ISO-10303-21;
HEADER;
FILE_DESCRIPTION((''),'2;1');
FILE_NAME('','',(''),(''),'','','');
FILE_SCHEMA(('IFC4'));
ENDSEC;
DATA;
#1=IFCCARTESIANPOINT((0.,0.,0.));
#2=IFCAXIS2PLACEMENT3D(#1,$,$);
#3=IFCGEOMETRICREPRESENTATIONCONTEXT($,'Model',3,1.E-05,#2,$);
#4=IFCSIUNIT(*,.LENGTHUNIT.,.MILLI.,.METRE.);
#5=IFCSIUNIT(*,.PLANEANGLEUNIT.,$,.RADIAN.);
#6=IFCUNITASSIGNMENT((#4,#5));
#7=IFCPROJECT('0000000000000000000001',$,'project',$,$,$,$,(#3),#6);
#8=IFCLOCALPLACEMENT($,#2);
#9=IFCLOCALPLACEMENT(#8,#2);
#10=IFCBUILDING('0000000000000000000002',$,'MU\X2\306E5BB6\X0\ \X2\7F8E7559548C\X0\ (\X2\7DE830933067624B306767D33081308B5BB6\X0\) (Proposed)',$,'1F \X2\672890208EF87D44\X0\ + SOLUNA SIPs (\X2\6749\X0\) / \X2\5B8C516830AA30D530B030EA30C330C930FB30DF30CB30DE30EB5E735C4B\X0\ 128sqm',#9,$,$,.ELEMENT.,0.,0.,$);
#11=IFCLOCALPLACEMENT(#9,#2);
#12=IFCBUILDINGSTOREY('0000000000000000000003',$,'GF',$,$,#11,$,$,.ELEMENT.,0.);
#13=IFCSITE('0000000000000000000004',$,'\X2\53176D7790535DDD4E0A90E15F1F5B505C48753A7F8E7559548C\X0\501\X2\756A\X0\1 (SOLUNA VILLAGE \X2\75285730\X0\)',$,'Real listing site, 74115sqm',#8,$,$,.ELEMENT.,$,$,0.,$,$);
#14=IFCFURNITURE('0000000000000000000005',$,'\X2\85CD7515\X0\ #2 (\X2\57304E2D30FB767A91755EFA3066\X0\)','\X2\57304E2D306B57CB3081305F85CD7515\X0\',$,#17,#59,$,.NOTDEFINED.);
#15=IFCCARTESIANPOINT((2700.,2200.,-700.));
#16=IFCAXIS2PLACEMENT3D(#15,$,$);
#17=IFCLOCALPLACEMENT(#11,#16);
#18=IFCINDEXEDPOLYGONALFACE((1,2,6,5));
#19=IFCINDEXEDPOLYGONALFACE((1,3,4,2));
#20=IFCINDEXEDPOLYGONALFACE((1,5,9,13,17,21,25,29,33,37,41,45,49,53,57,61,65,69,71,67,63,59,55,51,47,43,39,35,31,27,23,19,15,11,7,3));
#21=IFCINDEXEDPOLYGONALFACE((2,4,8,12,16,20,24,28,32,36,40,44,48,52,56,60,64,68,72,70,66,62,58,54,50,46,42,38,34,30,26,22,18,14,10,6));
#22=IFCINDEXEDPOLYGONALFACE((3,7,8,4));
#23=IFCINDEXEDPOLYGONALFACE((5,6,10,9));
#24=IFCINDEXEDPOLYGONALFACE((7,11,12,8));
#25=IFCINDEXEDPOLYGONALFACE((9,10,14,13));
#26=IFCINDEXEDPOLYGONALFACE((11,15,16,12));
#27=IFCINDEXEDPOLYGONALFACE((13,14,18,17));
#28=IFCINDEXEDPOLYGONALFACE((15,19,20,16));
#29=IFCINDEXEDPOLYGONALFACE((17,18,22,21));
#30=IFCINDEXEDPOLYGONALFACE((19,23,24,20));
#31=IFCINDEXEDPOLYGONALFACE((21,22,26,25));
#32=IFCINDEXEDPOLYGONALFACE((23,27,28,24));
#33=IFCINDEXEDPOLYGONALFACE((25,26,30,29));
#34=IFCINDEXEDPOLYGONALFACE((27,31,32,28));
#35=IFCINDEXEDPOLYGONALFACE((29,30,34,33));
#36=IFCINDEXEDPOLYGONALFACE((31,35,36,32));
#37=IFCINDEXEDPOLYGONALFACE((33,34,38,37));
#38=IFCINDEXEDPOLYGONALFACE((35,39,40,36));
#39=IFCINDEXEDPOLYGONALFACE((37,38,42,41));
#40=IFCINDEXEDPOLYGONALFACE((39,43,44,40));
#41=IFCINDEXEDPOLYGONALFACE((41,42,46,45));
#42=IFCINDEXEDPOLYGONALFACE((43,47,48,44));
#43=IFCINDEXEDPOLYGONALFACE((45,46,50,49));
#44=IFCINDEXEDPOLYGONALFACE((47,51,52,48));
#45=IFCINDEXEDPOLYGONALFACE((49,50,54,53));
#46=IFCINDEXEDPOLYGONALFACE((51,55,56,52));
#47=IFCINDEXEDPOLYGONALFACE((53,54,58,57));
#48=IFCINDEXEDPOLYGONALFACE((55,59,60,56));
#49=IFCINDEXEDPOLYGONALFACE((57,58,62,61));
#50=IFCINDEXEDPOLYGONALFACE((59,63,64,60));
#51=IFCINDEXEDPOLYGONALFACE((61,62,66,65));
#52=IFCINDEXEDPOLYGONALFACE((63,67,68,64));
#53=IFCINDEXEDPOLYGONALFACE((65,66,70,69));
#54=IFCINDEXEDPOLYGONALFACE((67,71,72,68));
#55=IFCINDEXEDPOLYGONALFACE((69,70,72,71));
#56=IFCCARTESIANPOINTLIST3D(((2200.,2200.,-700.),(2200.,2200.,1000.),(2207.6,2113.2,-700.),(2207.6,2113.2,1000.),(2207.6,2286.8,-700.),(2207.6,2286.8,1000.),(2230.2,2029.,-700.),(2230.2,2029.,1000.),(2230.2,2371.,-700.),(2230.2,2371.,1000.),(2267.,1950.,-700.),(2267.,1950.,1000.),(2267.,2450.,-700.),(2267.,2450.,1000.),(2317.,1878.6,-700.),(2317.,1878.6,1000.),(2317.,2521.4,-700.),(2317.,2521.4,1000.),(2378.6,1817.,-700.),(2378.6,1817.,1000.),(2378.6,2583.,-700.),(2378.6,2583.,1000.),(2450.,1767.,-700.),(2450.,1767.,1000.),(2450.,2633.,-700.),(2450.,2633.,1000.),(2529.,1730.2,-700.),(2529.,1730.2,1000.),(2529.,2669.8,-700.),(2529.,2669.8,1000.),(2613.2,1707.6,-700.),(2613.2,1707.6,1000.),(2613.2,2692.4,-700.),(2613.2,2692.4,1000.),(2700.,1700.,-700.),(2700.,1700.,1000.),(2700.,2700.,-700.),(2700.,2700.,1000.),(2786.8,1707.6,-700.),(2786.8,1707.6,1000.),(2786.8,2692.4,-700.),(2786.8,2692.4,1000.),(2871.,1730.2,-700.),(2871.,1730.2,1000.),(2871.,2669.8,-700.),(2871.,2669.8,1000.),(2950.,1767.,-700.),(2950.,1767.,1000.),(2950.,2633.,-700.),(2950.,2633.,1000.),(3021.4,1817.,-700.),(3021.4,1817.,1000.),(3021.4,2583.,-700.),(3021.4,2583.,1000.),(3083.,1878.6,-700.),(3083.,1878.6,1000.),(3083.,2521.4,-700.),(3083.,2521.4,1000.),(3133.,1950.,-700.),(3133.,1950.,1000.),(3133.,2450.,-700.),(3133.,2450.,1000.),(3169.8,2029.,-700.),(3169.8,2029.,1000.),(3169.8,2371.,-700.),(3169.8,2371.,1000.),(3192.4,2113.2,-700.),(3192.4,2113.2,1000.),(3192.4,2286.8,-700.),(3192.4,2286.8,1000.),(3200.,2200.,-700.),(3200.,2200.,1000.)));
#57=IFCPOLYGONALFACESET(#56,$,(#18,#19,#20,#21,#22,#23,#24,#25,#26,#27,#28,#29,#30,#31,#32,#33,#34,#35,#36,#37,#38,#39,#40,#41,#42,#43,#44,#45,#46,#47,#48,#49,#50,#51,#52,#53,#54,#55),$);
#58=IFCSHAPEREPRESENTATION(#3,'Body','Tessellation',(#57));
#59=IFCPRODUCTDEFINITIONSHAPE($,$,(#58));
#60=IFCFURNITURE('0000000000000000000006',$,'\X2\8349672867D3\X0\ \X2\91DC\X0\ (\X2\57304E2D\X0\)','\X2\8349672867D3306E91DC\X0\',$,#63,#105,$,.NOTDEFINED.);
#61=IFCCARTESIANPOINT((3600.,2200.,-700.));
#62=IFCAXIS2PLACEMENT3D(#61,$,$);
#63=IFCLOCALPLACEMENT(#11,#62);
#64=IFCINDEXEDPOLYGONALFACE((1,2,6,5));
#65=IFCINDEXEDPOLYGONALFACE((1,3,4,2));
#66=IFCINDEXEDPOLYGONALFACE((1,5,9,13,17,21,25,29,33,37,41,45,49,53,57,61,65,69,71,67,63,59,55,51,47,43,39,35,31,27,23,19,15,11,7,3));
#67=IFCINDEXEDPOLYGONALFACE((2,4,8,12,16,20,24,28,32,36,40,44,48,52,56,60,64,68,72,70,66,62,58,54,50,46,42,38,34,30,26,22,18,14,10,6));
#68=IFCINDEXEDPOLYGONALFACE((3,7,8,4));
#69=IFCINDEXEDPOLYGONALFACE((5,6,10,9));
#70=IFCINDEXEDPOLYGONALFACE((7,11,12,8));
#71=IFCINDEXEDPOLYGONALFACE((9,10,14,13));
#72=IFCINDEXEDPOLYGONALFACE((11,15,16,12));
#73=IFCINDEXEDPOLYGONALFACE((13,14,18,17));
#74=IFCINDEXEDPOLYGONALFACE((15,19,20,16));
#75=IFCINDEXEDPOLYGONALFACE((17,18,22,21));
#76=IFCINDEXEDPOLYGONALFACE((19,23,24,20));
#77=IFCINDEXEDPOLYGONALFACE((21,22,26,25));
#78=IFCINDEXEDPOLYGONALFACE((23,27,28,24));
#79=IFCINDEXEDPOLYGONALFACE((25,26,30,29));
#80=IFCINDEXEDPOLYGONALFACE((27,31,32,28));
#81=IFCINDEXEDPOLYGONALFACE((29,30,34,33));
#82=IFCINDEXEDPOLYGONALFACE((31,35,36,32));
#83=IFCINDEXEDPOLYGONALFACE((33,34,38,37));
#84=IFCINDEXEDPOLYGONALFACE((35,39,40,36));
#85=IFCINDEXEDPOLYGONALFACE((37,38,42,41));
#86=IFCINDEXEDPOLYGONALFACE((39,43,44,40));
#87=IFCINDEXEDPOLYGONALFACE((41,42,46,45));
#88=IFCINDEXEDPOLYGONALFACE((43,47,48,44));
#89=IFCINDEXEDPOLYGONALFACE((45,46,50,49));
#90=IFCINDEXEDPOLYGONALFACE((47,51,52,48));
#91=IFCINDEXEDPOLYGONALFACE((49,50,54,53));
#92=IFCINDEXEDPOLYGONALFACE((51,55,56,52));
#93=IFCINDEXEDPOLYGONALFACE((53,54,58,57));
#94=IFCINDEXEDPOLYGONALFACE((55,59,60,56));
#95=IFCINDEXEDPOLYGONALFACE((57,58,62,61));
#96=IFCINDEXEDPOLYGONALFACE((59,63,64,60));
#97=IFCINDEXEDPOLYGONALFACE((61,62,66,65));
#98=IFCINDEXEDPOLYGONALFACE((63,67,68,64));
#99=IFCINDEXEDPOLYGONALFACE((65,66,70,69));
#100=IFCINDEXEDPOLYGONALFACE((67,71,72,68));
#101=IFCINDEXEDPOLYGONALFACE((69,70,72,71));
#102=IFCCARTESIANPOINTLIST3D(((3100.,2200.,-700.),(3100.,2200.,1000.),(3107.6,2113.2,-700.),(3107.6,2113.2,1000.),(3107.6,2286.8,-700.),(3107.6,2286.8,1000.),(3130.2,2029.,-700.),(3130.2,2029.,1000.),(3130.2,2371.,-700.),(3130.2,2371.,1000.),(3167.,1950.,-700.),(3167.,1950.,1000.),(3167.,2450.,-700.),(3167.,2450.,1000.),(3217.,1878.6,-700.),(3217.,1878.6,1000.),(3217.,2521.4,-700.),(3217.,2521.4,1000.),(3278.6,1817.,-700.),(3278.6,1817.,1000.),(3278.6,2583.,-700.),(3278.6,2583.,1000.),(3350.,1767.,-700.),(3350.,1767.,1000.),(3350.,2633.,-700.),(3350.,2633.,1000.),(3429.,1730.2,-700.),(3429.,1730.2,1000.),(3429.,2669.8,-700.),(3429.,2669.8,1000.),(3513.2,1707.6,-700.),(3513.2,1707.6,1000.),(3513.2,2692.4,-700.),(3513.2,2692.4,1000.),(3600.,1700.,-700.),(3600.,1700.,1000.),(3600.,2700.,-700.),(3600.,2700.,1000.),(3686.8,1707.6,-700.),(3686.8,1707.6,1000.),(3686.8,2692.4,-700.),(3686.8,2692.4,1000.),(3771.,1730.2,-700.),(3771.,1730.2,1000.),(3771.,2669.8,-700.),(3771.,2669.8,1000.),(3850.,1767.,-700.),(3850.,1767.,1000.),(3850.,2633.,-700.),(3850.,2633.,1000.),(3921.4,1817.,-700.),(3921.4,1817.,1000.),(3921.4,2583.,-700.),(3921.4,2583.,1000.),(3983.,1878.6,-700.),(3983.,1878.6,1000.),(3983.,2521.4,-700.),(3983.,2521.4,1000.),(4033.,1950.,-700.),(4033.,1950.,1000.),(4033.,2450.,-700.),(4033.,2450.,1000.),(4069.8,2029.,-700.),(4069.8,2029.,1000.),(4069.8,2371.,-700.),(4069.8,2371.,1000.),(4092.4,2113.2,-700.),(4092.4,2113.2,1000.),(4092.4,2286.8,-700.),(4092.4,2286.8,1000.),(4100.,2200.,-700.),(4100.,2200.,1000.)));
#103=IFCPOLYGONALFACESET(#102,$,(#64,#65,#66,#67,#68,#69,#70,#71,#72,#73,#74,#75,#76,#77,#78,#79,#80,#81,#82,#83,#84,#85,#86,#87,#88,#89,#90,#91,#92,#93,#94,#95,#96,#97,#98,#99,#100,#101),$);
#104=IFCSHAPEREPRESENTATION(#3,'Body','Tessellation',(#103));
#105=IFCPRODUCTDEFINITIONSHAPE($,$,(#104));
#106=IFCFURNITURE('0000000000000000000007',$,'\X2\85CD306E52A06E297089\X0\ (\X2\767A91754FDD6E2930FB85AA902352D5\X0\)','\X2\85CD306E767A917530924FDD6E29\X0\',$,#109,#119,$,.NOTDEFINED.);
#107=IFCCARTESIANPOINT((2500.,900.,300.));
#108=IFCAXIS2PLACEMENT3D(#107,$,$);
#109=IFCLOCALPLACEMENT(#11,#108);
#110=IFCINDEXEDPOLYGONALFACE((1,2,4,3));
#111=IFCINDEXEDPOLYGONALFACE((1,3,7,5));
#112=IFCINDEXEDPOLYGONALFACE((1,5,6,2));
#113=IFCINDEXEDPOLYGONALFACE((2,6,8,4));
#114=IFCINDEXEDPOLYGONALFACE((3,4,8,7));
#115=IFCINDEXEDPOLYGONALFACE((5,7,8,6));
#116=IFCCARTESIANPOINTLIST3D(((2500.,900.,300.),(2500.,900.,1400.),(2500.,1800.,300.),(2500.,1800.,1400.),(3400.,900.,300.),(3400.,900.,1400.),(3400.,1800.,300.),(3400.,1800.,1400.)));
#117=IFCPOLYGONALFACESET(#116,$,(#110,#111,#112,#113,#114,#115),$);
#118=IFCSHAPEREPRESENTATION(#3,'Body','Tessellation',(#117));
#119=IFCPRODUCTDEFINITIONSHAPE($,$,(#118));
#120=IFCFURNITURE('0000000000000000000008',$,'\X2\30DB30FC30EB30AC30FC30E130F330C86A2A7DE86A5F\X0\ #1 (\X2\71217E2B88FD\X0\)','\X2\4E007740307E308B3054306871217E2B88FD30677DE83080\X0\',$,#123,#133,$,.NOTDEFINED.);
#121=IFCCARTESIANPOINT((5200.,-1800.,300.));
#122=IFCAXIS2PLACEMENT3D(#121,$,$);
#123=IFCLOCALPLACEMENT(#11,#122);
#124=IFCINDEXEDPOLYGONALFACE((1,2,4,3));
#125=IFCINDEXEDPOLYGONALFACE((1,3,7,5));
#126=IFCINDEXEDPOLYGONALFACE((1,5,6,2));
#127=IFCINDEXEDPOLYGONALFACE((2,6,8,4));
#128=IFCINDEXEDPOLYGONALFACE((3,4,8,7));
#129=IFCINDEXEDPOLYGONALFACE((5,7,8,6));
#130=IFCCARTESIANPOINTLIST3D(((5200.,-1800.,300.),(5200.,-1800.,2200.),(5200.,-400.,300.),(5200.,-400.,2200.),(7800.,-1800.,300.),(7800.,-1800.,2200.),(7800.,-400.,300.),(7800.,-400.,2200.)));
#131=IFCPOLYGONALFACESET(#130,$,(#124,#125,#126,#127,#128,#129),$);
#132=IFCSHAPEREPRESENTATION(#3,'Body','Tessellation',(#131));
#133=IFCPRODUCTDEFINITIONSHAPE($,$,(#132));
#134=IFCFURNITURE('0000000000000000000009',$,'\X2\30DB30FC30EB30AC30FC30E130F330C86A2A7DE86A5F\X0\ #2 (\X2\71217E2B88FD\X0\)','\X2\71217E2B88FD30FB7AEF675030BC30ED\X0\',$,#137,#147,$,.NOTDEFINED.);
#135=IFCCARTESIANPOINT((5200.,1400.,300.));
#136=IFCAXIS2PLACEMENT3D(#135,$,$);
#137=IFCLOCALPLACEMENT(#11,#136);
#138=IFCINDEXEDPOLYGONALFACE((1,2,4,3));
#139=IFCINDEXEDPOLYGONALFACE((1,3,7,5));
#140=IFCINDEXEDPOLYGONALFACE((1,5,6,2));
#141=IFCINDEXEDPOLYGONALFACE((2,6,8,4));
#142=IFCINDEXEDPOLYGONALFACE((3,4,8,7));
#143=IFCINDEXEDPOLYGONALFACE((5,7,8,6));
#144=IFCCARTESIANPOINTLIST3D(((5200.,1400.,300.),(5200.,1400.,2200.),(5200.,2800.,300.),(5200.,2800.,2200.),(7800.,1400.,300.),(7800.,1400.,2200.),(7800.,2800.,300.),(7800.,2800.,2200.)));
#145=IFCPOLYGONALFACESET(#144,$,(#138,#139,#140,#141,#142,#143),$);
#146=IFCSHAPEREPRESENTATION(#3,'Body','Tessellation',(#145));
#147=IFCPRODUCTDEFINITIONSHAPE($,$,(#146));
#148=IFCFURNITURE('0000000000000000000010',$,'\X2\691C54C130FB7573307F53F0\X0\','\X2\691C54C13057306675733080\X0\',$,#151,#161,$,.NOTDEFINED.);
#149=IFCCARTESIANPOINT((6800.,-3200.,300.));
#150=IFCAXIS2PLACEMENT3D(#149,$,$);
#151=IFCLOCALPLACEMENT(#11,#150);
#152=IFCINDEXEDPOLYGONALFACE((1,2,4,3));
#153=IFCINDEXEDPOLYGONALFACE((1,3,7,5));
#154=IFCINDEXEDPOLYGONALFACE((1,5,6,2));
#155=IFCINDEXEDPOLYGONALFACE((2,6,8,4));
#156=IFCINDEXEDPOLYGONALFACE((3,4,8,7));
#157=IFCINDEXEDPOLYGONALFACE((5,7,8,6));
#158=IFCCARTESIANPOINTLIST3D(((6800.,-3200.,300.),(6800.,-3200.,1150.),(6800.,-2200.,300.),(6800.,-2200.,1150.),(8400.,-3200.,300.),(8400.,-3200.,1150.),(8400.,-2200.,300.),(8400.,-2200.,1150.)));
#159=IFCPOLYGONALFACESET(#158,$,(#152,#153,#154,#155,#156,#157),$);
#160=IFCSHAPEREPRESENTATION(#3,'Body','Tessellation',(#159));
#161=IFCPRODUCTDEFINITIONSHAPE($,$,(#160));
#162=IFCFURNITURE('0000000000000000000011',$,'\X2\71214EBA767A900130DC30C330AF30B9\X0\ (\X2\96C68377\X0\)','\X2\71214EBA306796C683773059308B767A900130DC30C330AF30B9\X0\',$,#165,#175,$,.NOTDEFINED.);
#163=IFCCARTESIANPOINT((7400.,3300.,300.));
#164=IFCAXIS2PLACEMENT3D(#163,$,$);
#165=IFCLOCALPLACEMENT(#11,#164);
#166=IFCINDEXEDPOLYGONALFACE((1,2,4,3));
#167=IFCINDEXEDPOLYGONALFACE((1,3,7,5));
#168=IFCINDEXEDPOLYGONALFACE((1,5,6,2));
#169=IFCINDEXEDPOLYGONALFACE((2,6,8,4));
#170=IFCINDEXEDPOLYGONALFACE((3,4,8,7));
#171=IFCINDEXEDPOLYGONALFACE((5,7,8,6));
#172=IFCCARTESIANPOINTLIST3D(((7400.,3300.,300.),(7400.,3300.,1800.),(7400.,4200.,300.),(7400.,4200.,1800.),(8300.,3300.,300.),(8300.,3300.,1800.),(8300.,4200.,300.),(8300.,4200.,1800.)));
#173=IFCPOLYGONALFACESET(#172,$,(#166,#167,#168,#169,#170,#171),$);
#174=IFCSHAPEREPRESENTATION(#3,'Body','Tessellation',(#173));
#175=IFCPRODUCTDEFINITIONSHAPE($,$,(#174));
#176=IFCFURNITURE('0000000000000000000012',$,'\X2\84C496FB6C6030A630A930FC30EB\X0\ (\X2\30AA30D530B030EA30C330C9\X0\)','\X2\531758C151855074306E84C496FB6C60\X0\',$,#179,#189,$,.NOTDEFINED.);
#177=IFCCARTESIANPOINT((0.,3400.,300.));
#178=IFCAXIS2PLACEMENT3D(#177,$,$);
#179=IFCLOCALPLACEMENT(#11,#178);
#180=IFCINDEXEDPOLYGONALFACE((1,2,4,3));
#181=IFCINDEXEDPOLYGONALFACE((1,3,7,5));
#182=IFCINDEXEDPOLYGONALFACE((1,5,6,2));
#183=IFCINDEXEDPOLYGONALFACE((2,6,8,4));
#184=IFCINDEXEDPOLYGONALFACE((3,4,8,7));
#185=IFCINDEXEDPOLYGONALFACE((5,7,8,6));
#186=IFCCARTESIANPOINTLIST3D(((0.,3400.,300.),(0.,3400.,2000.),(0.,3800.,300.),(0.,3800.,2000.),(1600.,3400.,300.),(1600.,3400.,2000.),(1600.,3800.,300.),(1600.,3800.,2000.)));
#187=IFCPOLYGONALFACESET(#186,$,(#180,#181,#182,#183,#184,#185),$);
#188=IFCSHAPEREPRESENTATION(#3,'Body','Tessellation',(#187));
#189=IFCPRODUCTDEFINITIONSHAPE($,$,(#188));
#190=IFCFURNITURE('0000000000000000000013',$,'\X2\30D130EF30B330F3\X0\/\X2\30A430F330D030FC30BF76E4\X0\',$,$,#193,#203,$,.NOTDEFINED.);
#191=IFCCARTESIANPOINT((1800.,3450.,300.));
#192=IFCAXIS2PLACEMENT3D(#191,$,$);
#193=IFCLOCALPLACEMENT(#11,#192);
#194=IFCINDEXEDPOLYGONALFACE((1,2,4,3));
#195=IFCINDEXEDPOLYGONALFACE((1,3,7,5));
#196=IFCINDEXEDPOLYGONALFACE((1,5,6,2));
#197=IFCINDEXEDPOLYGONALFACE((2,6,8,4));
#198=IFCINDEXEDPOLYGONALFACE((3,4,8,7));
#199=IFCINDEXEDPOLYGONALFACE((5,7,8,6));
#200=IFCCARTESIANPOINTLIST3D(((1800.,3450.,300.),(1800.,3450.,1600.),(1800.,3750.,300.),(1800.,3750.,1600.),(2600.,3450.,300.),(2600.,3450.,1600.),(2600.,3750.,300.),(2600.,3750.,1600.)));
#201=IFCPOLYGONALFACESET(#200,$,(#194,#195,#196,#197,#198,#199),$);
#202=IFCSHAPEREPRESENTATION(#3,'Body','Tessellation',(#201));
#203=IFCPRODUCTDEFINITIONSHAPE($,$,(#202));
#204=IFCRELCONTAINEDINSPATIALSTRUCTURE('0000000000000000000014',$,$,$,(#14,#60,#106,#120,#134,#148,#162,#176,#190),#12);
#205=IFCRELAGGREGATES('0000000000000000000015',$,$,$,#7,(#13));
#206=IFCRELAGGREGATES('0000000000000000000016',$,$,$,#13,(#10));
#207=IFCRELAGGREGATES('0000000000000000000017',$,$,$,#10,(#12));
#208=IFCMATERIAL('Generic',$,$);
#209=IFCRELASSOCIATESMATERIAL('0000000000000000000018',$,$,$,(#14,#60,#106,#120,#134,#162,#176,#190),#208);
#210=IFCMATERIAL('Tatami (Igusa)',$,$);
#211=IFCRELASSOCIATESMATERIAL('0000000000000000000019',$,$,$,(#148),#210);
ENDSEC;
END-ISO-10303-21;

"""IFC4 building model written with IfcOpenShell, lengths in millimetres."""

from ifc_helpers import new_model, si_unit, frame, frame_2d, origin, origin_2d, place, context, project, spatial, rectangle, circle, extrude, material, element, save


model = new_model("IFC4")

# Units and contexts
model_context = context("Model", 3, precision=1e-05, world=origin())
ifc_project = project(units=[si_unit("LENGTHUNIT", "METRE", prefix="MILLI"), si_unit("PLANEANGLEUNIT", "RADIAN")], contexts=[model_context])

# Site, building, storey
site_placement = place(None, origin())
site = spatial("IfcSite", under=ifc_project, at=site_placement, Name="北海道川上郡弟子屈町美留和501番1 (SOLUNA VILLAGE 用地)", ObjectType="Real listing site, 74115sqm", CompositionType="ELEMENT", RefElevation=0.0)
building_placement = place(site_placement, origin())
building = spatial("IfcBuilding", under=site, at=building_placement, Name="MUの家 美留和 (編んで手で染める家) (Proposed)", ObjectType="1F 木造軸組 + SOLUNA SIPs (杉) / 完全オフグリッド・ミニマル平屋 128sqm", CompositionType="ELEMENT", ElevationOfRefHeight=0.0, ElevationOfTerrain=0.0)
storey_placement = place(building_placement, origin())
storey = spatial("IfcBuildingStorey", under=building, at=storey_placement, Name="GF", CompositionType="ELEMENT", Elevation=0.0)

# Shared definitions
ifc_material_1 = material(Name="Generic")

# Furniture
furniture_1_placement = place(storey_placement, frame((2700.0, 2200.0, -700.0)))
element("IfcFurniture", 1, at=furniture_1_placement, inside=storey, material=ifc_material_1, Name="藍甕 #2 (地中・発酵建て)", Description="地中に埋めた藍甕", PredefinedType="NOTDEFINED", context=model_context, shape_type="SweptSolid", body=[
    extrude(circle(Radius=500.0, at=origin_2d()), frame((2700.0, 2200.0, -700.0)), (0.0, 0.0, 1.0), 1700.0),
])
furniture_2_placement = place(storey_placement, frame((3600.0, 2200.0, -700.0)))
element("IfcFurniture", 2, at=furniture_2_placement, inside=storey, material=ifc_material_1, Name="草木染 釜 (地中)", Description="草木染の釜", PredefinedType="NOTDEFINED", context=model_context, shape_type="SweptSolid", body=[
    extrude(circle(Radius=500.0, at=origin_2d()), frame((3600.0, 2200.0, -700.0)), (0.0, 0.0, 1.0), 1700.0),
])
furniture_3_placement = place(storey_placement, frame((2500.0, 900.0, 300.0)))
element("IfcFurniture", 3, at=furniture_3_placement, inside=storey, material=ifc_material_1, Name="藍の加温炉 (発酵保温・薪連動)", Description="藍の発酵を保温", PredefinedType="NOTDEFINED", context=model_context, shape_type="SweptSolid", body=[
    extrude(rectangle(XDim=900.0, YDim=900.0, at=frame_2d((450.0, 450.0))), frame((2500.0, 900.0, 300.0)), (0.0, 0.0, 1.0), 1100.0),
])
furniture_4_placement = place(storey_placement, frame((5200.0, -1800.0, 300.0)))
element("IfcFurniture", 4, at=furniture_4_placement, inside=storey, material=ifc_material_1, Name="ホールガーメント横編機 #1 (無縫製)", Description="一着まるごと無縫製で編む", PredefinedType="NOTDEFINED", context=model_context, shape_type="SweptSolid", body=[
    extrude(rectangle(XDim=2600.0, YDim=1400.0, at=frame_2d((1300.0, 700.0))), frame((5200.0, -1800.0, 300.0)), (0.0, 0.0, 1.0), 1900.0),
])
furniture_5_placement = place(storey_placement, frame((5200.0, 1400.0, 300.0)))
element("IfcFurniture", 5, at=furniture_5_placement, inside=storey, material=ifc_material_1, Name="ホールガーメント横編機 #2 (無縫製)", Description="無縫製・端材ゼロ", PredefinedType="NOTDEFINED", context=model_context, shape_type="SweptSolid", body=[
    extrude(rectangle(XDim=2600.0, YDim=1400.0, at=frame_2d((1300.0, 700.0))), frame((5200.0, 1400.0, 300.0)), (0.0, 0.0, 1.0), 1900.0),
])
ifc_material_2 = material(Name="Tatami (Igusa)")
furniture_6_placement = place(storey_placement, frame((6800.0, -3200.0, 300.0)))
element("IfcFurniture", 6, at=furniture_6_placement, inside=storey, material=ifc_material_2, Name="検品・畳み台", Description="検品して畳む", PredefinedType="NOTDEFINED", context=model_context, shape_type="SweptSolid", body=[
    extrude(rectangle(XDim=1600.0, YDim=1000.0, at=frame_2d((800.0, 500.0))), frame((6800.0, -3200.0, 300.0)), (0.0, 0.0, 1.0), 850.0),
])
furniture_7_placement = place(storey_placement, frame((7400.0, 3300.0, 300.0)))
element("IfcFurniture", 7, at=furniture_7_placement, inside=storey, material=ifc_material_1, Name="無人発送ボックス (集荷)", Description="無人で集荷する発送ボックス", PredefinedType="NOTDEFINED", context=model_context, shape_type="SweptSolid", body=[
    extrude(rectangle(XDim=900.0, YDim=900.0, at=frame_2d((450.0, 450.0))), frame((7400.0, 3300.0, 300.0)), (0.0, 0.0, 1.0), 1500.0),
])
furniture_8_placement = place(storey_placement, frame((0.0, 3400.0, 300.0)))
element("IfcFurniture", 8, at=furniture_8_placement, inside=storey, material=ifc_material_1, Name="蓄電池ウォール (オフグリッド)", Description="北壁内側の蓄電池", PredefinedType="NOTDEFINED", context=model_context, shape_type="SweptSolid", body=[
    extrude(rectangle(XDim=1600.0, YDim=400.0, at=frame_2d((800.0, 200.0))), frame((0.0, 3400.0, 300.0)), (0.0, 0.0, 1.0), 1700.0),
])
furniture_9_placement = place(storey_placement, frame((1800.0, 3450.0, 300.0)))
element("IfcFurniture", 9, at=furniture_9_placement, inside=storey, material=ifc_material_1, Name="パワコン/インバータ盤", PredefinedType="NOTDEFINED", context=model_context, shape_type="SweptSolid", body=[
    extrude(rectangle(XDim=800.0, YDim=300.0, at=frame_2d((400.0, 150.0))), frame((1800.0, 3450.0, 300.0)), (0.0, 0.0, 1.0), 1300.0),
])

save(model, "model.ifc")
